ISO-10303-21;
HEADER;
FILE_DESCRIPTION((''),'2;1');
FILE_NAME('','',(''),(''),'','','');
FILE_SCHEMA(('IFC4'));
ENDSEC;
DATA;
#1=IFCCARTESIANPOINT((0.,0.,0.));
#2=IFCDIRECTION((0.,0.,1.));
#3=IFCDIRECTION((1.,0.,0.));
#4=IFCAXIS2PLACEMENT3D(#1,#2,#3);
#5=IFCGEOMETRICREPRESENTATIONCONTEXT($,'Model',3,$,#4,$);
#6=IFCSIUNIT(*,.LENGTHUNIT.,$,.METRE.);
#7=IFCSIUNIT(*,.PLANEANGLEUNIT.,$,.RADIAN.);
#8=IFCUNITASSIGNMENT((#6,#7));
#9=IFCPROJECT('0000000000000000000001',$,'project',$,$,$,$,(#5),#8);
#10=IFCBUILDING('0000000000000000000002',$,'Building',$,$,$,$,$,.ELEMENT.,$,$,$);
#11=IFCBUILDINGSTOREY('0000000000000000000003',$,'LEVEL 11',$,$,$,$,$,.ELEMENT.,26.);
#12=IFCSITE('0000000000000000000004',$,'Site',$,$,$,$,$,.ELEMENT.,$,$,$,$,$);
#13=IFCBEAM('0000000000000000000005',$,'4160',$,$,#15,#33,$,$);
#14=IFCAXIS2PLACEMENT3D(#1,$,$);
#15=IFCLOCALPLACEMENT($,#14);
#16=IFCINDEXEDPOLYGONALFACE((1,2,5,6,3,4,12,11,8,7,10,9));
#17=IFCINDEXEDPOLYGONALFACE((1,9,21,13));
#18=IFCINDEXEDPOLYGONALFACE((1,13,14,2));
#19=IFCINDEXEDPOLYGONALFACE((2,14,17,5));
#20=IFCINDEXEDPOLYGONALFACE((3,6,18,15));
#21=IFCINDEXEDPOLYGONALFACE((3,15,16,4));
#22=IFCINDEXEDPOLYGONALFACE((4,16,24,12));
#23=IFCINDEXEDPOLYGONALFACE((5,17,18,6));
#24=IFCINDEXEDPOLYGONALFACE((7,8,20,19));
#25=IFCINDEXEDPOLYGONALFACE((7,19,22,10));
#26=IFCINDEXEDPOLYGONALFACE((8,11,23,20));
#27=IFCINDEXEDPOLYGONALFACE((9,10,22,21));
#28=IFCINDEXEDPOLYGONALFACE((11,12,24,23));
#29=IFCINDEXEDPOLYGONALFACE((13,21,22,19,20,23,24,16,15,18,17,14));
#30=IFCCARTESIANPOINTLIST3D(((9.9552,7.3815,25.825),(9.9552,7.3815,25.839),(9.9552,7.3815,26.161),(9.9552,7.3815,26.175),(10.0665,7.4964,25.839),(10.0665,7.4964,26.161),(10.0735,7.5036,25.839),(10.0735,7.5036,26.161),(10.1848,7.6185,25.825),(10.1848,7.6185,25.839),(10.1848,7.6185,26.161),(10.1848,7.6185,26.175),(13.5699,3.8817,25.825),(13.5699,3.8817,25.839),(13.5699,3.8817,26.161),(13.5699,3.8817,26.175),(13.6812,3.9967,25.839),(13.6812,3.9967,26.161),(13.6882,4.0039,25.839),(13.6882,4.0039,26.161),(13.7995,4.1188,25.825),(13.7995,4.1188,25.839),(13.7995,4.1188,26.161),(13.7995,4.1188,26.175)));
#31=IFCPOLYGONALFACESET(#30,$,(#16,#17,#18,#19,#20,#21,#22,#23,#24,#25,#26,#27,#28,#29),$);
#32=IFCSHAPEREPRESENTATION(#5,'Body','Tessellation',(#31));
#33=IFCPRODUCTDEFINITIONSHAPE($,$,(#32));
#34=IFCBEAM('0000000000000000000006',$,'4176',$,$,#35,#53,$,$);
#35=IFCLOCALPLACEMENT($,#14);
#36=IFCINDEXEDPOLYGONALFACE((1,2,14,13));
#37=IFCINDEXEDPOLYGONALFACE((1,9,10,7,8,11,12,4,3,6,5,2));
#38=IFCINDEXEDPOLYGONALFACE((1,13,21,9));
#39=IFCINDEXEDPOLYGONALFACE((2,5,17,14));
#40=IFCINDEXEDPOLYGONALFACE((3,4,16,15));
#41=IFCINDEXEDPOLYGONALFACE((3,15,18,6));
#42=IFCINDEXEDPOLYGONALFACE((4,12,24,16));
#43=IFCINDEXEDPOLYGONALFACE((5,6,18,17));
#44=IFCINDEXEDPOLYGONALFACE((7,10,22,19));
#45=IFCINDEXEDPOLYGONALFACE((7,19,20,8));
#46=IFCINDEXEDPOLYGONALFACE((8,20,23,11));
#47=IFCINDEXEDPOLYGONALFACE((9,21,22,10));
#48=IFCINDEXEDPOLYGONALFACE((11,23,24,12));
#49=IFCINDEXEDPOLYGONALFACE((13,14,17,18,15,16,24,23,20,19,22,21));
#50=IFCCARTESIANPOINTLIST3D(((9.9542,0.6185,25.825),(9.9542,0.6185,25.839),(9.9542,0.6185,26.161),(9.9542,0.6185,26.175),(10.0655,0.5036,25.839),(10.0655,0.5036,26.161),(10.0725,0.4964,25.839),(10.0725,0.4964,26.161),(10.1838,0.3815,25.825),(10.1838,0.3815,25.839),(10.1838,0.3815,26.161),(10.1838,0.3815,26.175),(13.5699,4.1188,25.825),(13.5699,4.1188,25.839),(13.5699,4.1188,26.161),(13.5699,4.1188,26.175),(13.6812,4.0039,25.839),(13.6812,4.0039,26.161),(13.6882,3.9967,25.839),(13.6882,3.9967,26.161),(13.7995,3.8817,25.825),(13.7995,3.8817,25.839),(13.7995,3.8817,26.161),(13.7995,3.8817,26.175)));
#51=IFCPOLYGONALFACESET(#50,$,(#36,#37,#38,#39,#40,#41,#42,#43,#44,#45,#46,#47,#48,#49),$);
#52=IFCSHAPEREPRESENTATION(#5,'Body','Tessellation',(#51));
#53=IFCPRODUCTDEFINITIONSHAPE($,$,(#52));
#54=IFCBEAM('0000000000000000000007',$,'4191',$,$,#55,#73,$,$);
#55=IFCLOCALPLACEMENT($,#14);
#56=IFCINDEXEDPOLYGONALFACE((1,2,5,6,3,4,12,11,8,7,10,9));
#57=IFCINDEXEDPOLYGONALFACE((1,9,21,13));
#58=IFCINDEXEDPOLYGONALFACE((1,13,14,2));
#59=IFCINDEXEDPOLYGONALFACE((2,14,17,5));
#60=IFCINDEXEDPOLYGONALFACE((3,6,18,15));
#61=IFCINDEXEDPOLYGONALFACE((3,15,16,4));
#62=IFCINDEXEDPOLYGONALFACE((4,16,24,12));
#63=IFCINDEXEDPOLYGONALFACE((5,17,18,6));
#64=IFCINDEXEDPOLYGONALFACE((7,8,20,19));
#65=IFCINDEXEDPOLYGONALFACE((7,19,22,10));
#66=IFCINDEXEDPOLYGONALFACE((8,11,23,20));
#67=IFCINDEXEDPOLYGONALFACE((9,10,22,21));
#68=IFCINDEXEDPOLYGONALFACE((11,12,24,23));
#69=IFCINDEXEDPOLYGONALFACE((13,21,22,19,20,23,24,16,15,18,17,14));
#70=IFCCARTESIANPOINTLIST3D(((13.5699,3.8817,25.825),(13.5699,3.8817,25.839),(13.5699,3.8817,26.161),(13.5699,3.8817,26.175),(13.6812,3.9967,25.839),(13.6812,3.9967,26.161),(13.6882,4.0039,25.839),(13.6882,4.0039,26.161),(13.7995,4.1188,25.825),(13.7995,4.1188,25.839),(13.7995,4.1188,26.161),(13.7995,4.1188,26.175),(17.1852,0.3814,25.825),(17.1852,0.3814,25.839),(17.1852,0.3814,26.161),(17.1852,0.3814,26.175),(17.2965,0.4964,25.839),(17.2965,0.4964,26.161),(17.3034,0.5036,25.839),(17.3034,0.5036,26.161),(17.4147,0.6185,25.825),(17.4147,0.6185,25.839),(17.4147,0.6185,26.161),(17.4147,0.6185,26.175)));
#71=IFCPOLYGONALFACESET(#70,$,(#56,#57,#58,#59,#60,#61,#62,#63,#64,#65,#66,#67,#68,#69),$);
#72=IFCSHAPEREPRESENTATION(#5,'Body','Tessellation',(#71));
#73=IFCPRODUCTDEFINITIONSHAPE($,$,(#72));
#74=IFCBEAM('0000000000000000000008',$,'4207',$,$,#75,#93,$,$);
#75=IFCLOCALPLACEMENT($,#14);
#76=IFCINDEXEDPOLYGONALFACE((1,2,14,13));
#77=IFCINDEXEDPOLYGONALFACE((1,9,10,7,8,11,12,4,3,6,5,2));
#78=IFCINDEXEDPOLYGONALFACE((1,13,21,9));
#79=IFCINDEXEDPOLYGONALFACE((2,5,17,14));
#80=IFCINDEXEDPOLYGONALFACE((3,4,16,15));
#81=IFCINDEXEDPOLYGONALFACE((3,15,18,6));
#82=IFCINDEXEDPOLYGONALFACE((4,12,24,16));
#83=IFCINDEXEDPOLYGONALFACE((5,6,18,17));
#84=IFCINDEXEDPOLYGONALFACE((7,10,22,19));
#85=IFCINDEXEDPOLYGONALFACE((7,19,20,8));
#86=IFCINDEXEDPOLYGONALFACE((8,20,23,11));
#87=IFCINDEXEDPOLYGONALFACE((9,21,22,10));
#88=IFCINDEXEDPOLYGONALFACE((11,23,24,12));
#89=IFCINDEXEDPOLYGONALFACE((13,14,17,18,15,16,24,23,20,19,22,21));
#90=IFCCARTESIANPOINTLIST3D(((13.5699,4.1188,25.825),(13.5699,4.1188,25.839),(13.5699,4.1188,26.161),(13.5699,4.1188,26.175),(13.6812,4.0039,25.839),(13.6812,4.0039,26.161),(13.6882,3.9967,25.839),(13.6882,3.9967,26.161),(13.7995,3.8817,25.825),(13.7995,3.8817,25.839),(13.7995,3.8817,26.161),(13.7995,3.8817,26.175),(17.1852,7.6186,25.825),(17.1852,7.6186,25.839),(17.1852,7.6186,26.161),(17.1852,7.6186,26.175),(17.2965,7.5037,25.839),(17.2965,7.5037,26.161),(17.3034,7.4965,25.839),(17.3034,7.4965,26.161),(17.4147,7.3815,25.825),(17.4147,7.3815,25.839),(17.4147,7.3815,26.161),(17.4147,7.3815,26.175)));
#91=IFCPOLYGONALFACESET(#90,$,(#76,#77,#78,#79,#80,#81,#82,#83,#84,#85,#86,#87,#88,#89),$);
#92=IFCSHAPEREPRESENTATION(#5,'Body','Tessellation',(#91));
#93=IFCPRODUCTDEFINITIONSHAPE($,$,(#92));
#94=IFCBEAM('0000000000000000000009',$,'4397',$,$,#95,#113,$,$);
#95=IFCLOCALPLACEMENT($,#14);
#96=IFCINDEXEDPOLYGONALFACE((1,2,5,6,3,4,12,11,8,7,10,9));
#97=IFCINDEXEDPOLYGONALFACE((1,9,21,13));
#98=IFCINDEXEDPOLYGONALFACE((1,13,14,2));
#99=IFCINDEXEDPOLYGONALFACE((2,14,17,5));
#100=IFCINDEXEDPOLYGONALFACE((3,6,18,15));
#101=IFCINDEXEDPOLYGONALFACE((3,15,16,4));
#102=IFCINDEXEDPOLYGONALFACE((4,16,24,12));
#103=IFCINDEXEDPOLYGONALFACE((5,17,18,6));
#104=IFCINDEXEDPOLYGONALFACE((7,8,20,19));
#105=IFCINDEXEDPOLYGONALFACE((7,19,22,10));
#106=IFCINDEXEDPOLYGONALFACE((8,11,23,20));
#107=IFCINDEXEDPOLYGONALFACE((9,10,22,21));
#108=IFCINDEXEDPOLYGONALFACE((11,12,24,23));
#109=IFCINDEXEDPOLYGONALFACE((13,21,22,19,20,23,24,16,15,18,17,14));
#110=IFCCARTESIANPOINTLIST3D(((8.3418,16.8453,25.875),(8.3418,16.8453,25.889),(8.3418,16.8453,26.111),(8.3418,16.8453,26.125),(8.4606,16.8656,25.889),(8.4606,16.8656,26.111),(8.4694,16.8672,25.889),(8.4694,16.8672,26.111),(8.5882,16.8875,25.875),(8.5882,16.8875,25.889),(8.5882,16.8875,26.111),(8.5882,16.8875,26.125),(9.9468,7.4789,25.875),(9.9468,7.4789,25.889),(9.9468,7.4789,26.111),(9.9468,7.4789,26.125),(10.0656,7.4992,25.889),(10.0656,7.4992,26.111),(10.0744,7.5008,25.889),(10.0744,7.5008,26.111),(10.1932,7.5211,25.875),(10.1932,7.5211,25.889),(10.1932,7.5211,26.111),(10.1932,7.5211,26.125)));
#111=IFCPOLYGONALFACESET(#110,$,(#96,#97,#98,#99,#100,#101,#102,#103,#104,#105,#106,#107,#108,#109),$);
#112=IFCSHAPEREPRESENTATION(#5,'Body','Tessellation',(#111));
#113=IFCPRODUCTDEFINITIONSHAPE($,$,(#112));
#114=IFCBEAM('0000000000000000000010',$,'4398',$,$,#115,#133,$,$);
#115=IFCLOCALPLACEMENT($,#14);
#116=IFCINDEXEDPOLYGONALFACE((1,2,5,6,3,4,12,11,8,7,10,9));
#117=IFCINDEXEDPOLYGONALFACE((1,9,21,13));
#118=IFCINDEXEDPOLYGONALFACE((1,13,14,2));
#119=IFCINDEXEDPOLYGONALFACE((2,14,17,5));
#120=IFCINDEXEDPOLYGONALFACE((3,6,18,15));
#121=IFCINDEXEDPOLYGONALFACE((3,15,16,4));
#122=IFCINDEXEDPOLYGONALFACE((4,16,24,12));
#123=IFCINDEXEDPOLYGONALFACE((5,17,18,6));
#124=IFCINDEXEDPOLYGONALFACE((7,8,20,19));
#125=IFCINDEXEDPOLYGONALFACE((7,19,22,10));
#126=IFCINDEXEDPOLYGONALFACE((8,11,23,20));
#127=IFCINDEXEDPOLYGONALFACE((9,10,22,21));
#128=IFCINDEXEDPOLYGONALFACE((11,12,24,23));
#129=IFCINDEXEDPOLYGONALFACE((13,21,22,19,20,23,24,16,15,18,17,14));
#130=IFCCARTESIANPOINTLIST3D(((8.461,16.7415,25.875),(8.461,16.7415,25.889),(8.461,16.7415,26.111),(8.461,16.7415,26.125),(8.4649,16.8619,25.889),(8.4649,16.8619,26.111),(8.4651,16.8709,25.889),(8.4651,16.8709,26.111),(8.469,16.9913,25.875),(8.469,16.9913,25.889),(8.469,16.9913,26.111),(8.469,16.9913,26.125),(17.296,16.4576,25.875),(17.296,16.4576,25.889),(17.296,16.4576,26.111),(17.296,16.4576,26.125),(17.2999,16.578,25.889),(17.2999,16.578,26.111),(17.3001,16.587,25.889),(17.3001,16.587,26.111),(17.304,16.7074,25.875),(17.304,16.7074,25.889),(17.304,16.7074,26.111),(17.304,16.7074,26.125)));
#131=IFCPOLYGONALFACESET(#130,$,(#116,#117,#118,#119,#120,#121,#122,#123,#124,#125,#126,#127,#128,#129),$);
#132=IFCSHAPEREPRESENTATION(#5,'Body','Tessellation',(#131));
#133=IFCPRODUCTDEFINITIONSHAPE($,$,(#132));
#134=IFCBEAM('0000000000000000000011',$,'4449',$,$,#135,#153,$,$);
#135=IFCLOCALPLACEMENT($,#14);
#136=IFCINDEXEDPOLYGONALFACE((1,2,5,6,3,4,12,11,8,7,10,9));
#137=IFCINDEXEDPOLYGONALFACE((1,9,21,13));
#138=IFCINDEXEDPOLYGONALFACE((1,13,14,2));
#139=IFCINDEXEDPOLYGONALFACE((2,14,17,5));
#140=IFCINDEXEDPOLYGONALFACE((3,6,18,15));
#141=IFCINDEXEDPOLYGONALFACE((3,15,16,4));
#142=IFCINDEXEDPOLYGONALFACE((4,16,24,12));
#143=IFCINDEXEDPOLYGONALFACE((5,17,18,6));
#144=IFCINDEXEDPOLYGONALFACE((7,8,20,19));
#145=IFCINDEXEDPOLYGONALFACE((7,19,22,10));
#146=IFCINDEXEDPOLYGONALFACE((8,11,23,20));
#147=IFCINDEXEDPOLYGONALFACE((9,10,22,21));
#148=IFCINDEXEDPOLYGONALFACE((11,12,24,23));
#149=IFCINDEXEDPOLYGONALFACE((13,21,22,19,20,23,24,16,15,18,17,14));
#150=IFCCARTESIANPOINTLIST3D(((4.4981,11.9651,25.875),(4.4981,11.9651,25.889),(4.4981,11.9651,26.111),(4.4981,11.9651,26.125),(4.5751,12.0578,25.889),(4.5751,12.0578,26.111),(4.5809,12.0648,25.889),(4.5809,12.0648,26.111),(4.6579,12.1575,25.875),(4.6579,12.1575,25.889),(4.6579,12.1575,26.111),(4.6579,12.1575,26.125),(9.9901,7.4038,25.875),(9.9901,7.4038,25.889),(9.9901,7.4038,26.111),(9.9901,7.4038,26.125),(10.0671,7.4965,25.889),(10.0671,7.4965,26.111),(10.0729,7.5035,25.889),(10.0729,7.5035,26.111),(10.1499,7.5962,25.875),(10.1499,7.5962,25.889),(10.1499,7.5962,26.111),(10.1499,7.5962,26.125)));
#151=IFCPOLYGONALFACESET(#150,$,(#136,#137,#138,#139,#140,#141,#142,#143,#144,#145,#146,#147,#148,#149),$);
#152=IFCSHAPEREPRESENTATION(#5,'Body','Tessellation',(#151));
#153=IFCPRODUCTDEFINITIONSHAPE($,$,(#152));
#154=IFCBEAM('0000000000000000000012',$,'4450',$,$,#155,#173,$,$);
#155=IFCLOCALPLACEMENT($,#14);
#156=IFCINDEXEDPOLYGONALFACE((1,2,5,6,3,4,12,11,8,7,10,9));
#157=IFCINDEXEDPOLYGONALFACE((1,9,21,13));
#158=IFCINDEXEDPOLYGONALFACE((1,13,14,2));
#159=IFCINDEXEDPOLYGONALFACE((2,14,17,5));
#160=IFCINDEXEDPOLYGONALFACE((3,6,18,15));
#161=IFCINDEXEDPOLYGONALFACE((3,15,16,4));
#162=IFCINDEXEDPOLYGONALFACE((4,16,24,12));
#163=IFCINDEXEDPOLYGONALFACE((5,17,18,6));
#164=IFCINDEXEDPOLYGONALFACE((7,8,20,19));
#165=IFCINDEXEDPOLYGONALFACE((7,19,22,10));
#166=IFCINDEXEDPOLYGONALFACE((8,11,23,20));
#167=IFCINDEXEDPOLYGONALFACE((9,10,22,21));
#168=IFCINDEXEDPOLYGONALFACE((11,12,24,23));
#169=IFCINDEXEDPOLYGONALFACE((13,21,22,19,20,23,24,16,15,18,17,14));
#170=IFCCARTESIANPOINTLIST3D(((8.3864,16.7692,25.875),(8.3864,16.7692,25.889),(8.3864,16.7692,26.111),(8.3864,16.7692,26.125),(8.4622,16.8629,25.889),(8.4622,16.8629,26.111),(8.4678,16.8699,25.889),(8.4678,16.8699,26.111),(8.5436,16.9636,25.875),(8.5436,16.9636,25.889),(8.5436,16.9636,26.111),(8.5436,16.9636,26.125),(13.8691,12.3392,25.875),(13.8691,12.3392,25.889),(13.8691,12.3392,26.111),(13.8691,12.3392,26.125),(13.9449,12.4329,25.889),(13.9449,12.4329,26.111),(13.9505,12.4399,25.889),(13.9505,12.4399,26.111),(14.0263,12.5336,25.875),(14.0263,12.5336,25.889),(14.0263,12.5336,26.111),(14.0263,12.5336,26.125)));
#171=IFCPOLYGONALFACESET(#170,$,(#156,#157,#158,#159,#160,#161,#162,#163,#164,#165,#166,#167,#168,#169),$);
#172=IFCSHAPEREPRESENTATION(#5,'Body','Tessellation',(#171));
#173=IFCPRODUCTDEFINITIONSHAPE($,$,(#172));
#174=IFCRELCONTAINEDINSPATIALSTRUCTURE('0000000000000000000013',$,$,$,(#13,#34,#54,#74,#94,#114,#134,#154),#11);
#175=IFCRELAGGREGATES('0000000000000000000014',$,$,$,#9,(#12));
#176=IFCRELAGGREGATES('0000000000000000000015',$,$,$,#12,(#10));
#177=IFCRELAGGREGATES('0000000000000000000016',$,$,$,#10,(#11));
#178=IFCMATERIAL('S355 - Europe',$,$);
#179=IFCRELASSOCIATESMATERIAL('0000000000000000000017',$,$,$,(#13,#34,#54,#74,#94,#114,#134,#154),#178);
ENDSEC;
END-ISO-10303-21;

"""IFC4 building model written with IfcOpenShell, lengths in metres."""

from ifc_helpers import new_model, si_unit, frame, origin_with_axes, origin_2d_with_axis, place, context, project, spatial, i_section, extrude, material, material_profile, profile_set, profile_usage, element, save


model = new_model("IFC4")

# Units and contexts
model_context = context("Model", 3, world=origin_with_axes())
ifc_project = project(units=[si_unit("LENGTHUNIT", "METRE"), si_unit("PLANEANGLEUNIT", "RADIAN")], contexts=[model_context])

# Site, building, storey
site = spatial("IfcSite", under=ifc_project, Name="Site", CompositionType="ELEMENT")
building = spatial("IfcBuilding", under=site, Name="Building", CompositionType="ELEMENT")
storey = spatial("IfcBuildingStorey", under=building, Name="LEVEL 11", CompositionType="ELEMENT", Elevation=26.0)

# Shared definitions
ifc_material = material(Name="S355 - Europe")

# Beams
ifc_material_profile_1 = material_profile(ifc_material, i_section(OverallWidth=0.33, OverallDepth=0.35, WebThickness=0.01, FlangeThickness=0.014, at=origin_2d_with_axis()))
ifc_profile_set_1 = profile_set([ifc_material_profile_1])
ifc_profile_usage_1 = profile_usage(ifc_profile_set_1, cardinal=10)
beam_1_placement = place(None, frame((10.07, 7.5, 26.0), z_axis=(0.718439, -0.69559, 0.0), x_axis=(0.69559, 0.718439, 0.0)))
element("IfcBeam", 1, at=beam_1_placement, inside=storey, material=ifc_profile_usage_1, Name="4160", context=model_context, shape_type="SweptSolid", body=[
    extrude(i_section(OverallWidth=0.33, OverallDepth=0.35, WebThickness=0.01, FlangeThickness=0.014, at=origin_2d_with_axis()), origin_with_axes(), (0.0, 0.0, 1.0), 5.0313),
])
ifc_material_profile_2 = material_profile(ifc_material, i_section(OverallWidth=0.33, OverallDepth=0.35, WebThickness=0.01, FlangeThickness=0.014, at=origin_2d_with_axis()))
ifc_profile_set_2 = profile_set([ifc_material_profile_2])
ifc_profile_usage_2 = profile_usage(ifc_profile_set_2, cardinal=10)
beam_2_placement = place(None, frame((10.069, 0.5, 26.0), z_axis=(0.718483, 0.695544, 0.0), x_axis=(-0.695544, 0.718483, 0.0)))
element("IfcBeam", 2, at=beam_2_placement, inside=storey, material=ifc_profile_usage_2, Name="4176", context=model_context, shape_type="SweptSolid", body=[
    extrude(i_section(OverallWidth=0.33, OverallDepth=0.35, WebThickness=0.01, FlangeThickness=0.014, at=origin_2d_with_axis()), origin_with_axes(), (0.0, 0.0, 1.0), 5.0324),
])
ifc_material_profile_3 = material_profile(ifc_material, i_section(OverallWidth=0.33, OverallDepth=0.35, WebThickness=0.01, FlangeThickness=0.014, at=origin_2d_with_axis()))
ifc_profile_set_3 = profile_set([ifc_material_profile_3])
ifc_profile_usage_3 = profile_usage(ifc_profile_set_3, cardinal=10)
beam_3_placement = place(None, frame((13.6847, 4.0003, 26.0), z_axis=(0.718439, -0.69559, 0.0), x_axis=(0.69559, 0.718439, 0.0)))
element("IfcBeam", 3, at=beam_3_placement, inside=storey, material=ifc_profile_usage_3, Name="4191", context=model_context, shape_type="SweptSolid", body=[
    extrude(i_section(OverallWidth=0.33, OverallDepth=0.35, WebThickness=0.01, FlangeThickness=0.014, at=origin_2d_with_axis()), origin_with_axes(), (0.0, 0.0, 1.0), 5.0321),
])
ifc_material_profile_4 = material_profile(ifc_material, i_section(OverallWidth=0.33, OverallDepth=0.35, WebThickness=0.01, FlangeThickness=0.014, at=origin_2d_with_axis()))
ifc_profile_set_4 = profile_set([ifc_material_profile_4])
ifc_profile_usage_4 = profile_usage(ifc_profile_set_4, cardinal=10)
beam_4_placement = place(None, frame((13.6847, 4.0003, 26.0), z_axis=(0.718483, 0.695544, 0.0), x_axis=(-0.695544, 0.718483, 0.0)))
element("IfcBeam", 4, at=beam_4_placement, inside=storey, material=ifc_profile_usage_4, Name="4207", context=model_context, shape_type="SweptSolid", body=[
    extrude(i_section(OverallWidth=0.33, OverallDepth=0.35, WebThickness=0.01, FlangeThickness=0.014, at=origin_2d_with_axis()), origin_with_axes(), (0.0, 0.0, 1.0), 5.0318),
])
ifc_material_profile_5 = material_profile(ifc_material, i_section(OverallWidth=0.25, OverallDepth=0.25, WebThickness=0.009, FlangeThickness=0.014, at=origin_2d_with_axis()))
ifc_profile_set_5 = profile_set([ifc_material_profile_5])
ifc_profile_usage_5 = profile_usage(ifc_profile_set_5, cardinal=10)
beam_5_placement = place(None, frame((10.07, 7.5, 26.0), z_axis=(-0.168895, 0.985634, 0.0), x_axis=(-0.985634, -0.168895, 0.0)))
element("IfcBeam", 5, at=beam_5_placement, inside=storey, material=ifc_profile_usage_5, Name="4397", context=model_context, shape_type="SweptSolid", body=[
    extrude(i_section(OverallWidth=0.25, OverallDepth=0.25, WebThickness=0.009, FlangeThickness=0.014, at=origin_2d_with_axis()), origin_with_axes(), (0.0, 0.0, 1.0), 9.5029),
])
ifc_material_profile_6 = material_profile(ifc_material, i_section(OverallWidth=0.25, OverallDepth=0.25, WebThickness=0.009, FlangeThickness=0.014, at=origin_2d_with_axis()))
ifc_profile_set_6 = profile_set([ifc_material_profile_6])
ifc_profile_usage_6 = profile_usage(ifc_profile_set_6, cardinal=10)
beam_6_placement = place(None, frame((8.465, 16.8664, 26.0), z_axis=(0.999484, -0.032117, 0.0), x_axis=(0.032117, 0.999484, 0.0)))
element("IfcBeam", 6, at=beam_6_placement, inside=storey, material=ifc_profile_usage_6, Name="4398", context=model_context, shape_type="SweptSolid", body=[
    extrude(i_section(OverallWidth=0.25, OverallDepth=0.25, WebThickness=0.009, FlangeThickness=0.014, at=origin_2d_with_axis()), origin_with_axes(), (0.0, 0.0, 1.0), 8.8396),
])
ifc_material_profile_7 = material_profile(ifc_material, i_section(OverallWidth=0.25, OverallDepth=0.25, WebThickness=0.009, FlangeThickness=0.014, at=origin_2d_with_axis()))
ifc_profile_set_7 = profile_set([ifc_material_profile_7])
ifc_profile_usage_7 = profile_usage(ifc_profile_set_7, cardinal=10)
beam_7_placement = place(None, frame((10.07, 7.5, 26.0), z_axis=(-0.769279, 0.638913, 0.0), x_axis=(-0.638913, -0.769279, 0.0)))
element("IfcBeam", 7, at=beam_7_placement, inside=storey, material=ifc_profile_usage_7, Name="4449", context=model_context, shape_type="SweptSolid", body=[
    extrude(i_section(OverallWidth=0.25, OverallDepth=0.25, WebThickness=0.009, FlangeThickness=0.014, at=origin_2d_with_axis()), origin_with_axes(), (0.0, 0.0, 1.0), 7.1392),
])
ifc_material_profile_8 = material_profile(ifc_material, i_section(OverallWidth=0.25, OverallDepth=0.25, WebThickness=0.009, FlangeThickness=0.014, at=origin_2d_with_axis()))
ifc_profile_set_8 = profile_set([ifc_material_profile_8])
ifc_profile_usage_8 = profile_usage(ifc_profile_set_8, cardinal=10)
beam_8_placement = place(None, frame((13.9477, 12.4364, 26.0), z_axis=(-0.777826, 0.62848, 0.0), x_axis=(-0.62848, -0.777826, 0.0)))
element("IfcBeam", 8, at=beam_8_placement, inside=storey, material=ifc_profile_usage_8, Name="4450", context=model_context, shape_type="SweptSolid", body=[
    extrude(i_section(OverallWidth=0.25, OverallDepth=0.25, WebThickness=0.009, FlangeThickness=0.014, at=origin_2d_with_axis()), origin_with_axes(), (0.0, 0.0, 1.0), 7.0488),
])

save(model, "model.ifc")
